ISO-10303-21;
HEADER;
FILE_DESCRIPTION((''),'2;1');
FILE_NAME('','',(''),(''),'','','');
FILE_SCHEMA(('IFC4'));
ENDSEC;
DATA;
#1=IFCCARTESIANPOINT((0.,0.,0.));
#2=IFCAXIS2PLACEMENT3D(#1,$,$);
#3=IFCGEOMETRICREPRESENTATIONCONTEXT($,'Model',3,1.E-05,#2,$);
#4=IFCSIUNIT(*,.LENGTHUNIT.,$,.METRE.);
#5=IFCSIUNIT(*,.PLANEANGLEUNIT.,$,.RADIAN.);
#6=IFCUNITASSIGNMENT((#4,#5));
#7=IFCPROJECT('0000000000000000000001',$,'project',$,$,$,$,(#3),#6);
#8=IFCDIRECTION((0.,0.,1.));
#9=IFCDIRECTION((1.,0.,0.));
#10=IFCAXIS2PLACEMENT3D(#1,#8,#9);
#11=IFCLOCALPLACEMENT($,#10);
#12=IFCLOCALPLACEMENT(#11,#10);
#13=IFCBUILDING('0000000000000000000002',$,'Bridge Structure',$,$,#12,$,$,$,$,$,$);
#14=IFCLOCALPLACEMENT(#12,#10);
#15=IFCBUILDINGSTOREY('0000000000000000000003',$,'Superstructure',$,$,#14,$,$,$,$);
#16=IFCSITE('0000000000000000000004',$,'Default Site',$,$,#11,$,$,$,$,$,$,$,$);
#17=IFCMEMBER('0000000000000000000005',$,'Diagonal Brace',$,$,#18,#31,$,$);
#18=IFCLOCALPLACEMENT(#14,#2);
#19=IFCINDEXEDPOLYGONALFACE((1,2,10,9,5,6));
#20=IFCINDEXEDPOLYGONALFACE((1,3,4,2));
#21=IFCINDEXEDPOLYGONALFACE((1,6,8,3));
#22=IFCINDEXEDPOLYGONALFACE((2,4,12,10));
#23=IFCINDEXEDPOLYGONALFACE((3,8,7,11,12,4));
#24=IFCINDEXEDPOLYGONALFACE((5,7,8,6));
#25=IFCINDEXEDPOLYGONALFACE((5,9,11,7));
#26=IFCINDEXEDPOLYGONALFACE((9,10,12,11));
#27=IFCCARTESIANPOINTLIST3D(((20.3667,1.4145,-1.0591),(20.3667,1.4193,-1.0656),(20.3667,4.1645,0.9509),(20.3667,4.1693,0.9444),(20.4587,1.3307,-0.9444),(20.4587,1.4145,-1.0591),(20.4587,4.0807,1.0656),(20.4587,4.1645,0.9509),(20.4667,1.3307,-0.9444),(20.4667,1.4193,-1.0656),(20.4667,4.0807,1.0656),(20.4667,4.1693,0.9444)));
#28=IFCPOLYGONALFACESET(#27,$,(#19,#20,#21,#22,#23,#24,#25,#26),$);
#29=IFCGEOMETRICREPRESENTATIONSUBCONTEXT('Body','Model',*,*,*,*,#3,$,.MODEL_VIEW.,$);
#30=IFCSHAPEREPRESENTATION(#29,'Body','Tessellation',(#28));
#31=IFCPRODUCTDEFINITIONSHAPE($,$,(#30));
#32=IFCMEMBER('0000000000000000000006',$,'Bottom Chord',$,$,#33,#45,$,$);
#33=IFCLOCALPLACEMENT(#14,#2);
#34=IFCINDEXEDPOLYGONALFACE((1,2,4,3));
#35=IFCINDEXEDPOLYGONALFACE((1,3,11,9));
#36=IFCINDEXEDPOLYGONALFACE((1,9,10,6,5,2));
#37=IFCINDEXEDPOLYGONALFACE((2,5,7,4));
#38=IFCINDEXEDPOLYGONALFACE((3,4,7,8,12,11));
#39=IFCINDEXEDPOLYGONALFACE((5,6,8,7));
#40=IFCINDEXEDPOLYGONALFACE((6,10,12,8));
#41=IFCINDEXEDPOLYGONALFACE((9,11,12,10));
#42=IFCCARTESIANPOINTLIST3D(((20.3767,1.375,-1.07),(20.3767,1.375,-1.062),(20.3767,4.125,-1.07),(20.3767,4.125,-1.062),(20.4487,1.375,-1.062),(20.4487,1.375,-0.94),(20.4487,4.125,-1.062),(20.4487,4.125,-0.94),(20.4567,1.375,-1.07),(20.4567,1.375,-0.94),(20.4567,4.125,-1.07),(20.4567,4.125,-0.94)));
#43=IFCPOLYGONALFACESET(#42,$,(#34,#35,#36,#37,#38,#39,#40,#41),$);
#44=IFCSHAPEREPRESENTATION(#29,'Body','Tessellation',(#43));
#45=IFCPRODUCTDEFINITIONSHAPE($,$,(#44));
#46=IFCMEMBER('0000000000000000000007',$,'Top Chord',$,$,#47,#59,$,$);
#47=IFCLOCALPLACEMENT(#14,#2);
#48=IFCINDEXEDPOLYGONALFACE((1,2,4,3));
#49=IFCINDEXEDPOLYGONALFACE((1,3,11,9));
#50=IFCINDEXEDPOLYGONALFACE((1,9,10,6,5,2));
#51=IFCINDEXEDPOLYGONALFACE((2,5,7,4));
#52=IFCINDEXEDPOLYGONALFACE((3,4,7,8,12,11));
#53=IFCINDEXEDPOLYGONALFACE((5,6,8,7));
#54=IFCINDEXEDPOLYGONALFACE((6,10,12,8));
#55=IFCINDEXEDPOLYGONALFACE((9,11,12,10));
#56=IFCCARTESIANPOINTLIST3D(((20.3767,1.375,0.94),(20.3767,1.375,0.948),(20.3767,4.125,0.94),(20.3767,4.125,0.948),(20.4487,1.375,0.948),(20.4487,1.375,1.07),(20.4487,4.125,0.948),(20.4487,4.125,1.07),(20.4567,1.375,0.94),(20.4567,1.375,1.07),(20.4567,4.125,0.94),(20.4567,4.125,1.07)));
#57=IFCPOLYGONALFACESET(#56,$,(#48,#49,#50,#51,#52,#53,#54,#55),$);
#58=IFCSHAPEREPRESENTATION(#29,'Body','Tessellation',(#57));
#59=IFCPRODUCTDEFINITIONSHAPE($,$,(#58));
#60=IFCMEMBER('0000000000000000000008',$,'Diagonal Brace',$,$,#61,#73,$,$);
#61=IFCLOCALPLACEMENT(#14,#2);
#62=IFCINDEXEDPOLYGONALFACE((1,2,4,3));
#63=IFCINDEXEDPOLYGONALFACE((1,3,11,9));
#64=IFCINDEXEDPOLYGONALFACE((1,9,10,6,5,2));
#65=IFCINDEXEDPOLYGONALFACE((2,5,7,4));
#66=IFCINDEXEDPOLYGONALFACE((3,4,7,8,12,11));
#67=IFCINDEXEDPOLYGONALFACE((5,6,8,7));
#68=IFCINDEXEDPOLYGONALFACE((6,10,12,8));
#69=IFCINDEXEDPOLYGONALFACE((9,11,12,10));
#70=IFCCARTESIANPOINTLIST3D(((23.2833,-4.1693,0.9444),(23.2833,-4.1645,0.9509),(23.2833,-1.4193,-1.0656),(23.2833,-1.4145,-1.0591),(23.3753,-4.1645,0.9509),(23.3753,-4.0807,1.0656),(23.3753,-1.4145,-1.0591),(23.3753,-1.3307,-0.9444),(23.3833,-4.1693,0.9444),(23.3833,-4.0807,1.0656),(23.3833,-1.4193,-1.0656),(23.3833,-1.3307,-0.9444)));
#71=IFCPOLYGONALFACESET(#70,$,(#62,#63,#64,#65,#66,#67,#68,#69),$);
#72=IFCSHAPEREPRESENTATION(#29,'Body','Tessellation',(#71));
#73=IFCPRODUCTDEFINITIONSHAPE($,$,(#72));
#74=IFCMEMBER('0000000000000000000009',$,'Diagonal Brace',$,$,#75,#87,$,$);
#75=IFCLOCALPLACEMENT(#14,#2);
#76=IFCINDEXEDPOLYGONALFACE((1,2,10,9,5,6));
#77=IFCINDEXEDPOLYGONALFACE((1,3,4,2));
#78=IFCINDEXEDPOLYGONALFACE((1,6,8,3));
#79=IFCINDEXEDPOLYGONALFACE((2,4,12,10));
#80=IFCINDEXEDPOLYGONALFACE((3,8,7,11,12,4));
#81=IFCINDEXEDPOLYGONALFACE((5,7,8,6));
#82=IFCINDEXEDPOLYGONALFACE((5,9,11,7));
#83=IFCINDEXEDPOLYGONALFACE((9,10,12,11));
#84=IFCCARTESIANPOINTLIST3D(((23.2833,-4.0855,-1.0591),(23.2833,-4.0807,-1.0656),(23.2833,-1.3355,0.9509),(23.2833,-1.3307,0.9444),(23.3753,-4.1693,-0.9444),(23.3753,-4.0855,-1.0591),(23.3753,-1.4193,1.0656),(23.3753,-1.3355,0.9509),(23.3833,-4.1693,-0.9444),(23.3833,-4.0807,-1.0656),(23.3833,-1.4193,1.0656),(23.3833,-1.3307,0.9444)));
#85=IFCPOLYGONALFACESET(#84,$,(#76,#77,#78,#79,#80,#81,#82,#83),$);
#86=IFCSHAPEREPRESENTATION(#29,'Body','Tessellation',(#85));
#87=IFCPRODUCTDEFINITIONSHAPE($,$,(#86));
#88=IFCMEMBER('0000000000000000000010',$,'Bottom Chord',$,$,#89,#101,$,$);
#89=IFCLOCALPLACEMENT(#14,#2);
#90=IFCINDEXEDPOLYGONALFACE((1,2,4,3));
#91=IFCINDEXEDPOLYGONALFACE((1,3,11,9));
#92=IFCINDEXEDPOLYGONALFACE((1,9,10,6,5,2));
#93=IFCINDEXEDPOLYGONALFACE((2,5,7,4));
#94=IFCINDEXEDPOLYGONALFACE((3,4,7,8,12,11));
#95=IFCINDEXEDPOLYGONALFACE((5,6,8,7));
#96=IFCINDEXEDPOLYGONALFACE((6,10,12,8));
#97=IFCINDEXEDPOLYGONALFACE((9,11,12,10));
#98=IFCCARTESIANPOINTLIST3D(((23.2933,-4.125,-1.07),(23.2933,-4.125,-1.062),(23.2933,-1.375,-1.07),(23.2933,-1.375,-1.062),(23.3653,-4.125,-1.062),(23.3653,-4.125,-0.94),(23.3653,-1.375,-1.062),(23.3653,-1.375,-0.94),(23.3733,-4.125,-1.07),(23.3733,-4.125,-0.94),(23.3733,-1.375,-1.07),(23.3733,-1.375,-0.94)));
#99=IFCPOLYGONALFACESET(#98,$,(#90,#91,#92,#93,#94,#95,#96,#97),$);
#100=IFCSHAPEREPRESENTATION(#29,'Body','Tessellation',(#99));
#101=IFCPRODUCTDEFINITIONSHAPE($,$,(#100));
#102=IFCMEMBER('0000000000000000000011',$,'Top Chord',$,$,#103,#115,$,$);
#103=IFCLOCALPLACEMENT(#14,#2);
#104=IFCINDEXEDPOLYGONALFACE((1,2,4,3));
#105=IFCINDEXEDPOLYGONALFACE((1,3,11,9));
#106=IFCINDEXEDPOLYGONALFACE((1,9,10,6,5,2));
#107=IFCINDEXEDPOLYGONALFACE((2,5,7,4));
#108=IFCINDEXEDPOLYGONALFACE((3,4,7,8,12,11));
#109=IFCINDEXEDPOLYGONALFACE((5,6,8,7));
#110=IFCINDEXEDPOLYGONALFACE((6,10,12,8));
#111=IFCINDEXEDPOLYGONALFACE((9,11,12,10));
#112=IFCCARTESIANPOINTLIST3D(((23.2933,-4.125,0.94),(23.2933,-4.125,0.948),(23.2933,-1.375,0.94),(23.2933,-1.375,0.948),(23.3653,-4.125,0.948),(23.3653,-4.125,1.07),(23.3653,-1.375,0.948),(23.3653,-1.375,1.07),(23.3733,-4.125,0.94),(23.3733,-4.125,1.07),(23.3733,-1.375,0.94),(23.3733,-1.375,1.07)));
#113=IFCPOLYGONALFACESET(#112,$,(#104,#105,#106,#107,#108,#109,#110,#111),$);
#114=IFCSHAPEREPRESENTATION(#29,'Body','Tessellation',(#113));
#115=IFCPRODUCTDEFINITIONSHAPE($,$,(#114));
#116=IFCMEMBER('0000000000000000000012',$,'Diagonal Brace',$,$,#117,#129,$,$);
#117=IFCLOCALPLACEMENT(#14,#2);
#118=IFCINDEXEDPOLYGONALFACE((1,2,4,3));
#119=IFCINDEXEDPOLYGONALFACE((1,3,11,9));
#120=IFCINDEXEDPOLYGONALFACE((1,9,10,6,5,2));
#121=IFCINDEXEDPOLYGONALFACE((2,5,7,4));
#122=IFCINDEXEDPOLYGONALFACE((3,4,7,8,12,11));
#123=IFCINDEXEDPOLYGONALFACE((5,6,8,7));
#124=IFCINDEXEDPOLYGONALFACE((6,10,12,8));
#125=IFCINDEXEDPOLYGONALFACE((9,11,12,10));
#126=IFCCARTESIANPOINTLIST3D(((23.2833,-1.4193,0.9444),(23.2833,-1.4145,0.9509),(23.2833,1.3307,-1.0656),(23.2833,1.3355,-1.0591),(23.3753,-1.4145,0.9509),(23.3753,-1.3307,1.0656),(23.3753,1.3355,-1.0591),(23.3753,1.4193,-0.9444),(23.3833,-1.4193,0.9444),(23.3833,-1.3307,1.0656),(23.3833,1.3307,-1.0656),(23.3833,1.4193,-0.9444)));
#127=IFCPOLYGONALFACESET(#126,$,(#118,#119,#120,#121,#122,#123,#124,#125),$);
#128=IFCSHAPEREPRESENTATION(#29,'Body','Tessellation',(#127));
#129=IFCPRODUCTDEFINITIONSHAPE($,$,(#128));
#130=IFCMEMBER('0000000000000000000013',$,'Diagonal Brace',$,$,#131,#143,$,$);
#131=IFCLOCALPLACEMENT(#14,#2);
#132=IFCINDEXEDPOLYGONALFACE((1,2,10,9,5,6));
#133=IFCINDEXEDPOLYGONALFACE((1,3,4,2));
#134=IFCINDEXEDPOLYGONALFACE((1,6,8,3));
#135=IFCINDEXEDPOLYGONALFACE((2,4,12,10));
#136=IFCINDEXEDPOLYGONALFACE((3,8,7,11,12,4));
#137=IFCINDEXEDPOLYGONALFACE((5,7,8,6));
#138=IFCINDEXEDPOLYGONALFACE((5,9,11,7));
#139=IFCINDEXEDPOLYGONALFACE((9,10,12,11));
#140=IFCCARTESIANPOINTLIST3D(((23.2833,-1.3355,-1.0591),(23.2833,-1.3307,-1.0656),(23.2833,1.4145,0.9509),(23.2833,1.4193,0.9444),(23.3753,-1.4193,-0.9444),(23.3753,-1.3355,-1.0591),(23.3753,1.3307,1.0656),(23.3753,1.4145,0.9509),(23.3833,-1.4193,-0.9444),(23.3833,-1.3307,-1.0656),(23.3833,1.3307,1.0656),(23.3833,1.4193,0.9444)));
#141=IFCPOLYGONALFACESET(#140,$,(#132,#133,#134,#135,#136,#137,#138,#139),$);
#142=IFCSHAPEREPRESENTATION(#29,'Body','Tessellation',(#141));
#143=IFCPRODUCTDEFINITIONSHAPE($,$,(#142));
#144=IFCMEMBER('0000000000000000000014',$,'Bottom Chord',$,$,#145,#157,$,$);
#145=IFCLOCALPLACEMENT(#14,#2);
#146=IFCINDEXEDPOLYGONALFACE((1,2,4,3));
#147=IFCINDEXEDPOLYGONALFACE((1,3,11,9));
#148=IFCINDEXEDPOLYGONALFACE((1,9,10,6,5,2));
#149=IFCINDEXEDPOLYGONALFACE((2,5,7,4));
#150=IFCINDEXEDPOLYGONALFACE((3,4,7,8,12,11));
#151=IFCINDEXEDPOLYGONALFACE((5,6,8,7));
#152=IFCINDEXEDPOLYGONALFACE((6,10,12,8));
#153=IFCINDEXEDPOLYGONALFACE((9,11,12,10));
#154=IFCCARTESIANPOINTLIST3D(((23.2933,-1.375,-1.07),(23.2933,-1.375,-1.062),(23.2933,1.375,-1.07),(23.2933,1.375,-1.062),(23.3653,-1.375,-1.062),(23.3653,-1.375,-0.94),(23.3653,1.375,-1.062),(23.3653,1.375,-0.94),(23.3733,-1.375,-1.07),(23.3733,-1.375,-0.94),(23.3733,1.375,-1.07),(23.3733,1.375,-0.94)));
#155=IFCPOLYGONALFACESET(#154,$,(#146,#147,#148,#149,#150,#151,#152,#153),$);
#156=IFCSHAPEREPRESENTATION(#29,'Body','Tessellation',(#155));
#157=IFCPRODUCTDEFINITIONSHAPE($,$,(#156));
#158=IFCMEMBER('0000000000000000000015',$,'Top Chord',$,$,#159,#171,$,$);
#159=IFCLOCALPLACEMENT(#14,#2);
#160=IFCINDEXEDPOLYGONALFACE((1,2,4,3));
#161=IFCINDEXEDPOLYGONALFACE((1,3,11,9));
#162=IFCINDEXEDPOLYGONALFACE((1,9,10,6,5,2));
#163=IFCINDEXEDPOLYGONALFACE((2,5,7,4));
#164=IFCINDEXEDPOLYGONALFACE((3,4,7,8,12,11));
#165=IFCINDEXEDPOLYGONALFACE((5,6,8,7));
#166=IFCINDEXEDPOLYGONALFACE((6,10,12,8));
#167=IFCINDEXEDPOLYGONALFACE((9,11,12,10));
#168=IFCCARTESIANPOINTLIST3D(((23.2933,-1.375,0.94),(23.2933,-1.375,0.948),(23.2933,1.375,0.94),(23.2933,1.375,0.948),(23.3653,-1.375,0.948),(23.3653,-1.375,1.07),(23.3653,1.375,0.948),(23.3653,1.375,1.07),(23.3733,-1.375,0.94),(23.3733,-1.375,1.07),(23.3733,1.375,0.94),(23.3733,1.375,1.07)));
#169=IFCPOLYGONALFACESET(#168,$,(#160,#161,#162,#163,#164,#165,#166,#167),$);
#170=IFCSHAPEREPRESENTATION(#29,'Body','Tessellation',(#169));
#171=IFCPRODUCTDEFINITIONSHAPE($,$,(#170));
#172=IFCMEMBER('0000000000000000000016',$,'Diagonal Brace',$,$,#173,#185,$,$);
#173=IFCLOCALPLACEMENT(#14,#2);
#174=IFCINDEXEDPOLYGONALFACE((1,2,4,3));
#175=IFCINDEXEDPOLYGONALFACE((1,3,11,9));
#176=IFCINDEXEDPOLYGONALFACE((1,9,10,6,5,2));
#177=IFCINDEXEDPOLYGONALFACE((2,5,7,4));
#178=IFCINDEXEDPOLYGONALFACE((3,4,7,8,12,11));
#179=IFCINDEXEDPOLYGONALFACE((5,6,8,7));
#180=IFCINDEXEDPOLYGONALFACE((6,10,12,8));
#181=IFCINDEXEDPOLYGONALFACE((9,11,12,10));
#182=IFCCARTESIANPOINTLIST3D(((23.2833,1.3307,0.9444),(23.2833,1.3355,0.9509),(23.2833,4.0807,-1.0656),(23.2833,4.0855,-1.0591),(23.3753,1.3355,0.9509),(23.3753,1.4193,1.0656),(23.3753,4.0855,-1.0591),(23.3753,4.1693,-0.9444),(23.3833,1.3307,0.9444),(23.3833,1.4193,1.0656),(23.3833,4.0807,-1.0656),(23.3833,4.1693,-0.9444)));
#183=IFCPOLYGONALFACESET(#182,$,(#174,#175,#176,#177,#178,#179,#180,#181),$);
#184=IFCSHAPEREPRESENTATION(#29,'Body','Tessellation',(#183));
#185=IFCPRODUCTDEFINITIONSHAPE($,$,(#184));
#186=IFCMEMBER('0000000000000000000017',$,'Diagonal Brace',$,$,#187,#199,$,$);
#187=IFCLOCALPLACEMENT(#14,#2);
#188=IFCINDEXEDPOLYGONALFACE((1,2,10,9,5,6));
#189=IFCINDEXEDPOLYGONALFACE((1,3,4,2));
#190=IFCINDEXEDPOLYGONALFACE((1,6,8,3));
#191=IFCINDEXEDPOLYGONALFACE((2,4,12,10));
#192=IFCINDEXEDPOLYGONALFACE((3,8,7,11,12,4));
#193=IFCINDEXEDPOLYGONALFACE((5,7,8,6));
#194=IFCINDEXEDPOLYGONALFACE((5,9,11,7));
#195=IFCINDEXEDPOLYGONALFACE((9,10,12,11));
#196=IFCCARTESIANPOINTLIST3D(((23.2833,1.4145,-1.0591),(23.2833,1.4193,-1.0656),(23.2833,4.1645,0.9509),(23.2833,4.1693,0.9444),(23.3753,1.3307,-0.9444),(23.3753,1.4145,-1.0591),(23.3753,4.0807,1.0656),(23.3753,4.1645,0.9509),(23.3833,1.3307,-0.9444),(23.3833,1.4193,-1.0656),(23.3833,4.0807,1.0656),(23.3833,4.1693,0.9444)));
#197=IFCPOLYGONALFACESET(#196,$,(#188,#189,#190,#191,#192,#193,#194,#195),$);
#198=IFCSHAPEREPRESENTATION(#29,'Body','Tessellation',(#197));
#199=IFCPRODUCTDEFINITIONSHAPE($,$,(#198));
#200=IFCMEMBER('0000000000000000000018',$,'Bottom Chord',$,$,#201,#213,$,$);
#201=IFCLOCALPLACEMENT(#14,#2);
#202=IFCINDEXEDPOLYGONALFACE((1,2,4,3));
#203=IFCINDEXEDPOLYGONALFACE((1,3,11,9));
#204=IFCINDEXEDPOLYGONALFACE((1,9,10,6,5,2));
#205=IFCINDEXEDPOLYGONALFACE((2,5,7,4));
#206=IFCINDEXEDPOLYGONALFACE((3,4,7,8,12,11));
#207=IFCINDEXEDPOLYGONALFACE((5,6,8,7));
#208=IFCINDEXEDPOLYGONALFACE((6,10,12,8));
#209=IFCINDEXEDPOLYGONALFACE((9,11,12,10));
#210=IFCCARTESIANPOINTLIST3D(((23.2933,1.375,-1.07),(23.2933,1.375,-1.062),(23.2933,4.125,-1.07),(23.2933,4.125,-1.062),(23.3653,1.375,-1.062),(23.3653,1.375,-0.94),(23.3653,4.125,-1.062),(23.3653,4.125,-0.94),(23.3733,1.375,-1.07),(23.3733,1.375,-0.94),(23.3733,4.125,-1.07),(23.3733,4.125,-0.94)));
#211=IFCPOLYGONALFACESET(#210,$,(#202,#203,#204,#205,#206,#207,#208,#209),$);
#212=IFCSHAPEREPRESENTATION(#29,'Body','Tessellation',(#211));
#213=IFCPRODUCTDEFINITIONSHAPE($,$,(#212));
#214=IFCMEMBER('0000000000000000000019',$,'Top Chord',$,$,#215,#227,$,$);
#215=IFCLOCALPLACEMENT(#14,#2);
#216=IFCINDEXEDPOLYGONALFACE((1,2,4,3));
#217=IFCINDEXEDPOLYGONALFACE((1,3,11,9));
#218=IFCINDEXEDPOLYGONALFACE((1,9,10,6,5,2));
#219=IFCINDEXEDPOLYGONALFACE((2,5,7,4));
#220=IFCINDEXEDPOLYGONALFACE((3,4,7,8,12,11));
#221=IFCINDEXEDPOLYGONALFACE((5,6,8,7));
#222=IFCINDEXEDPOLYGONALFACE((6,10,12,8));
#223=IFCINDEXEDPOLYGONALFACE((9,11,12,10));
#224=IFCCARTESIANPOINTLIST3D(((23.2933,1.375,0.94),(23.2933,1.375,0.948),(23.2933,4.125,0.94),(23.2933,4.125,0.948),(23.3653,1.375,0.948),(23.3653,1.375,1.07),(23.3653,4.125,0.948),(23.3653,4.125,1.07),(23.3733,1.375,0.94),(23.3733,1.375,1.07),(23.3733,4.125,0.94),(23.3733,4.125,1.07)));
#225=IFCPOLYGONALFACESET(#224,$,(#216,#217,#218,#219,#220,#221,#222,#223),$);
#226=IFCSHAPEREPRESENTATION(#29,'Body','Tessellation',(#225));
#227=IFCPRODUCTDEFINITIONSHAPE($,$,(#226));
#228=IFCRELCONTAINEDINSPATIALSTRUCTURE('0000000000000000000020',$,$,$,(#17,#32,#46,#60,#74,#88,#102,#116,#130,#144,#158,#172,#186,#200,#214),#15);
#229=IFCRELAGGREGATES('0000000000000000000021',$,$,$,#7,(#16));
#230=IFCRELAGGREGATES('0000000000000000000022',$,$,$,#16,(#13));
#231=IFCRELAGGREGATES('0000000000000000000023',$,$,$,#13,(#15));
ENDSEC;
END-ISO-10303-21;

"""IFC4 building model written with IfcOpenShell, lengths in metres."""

from ifc_helpers import new_model, si_unit, frame, origin, origin_with_axes, origin_2d_with_axis, place, context, subcontext, project, spatial, l_section, extrude, element, save


model = new_model("IFC4")

# Units and contexts
model_context = context("Model", 3, precision=1e-05, world=origin())
body_context = subcontext(model_context, "Body", "Model", "MODEL_VIEW")
ifc_project = project(units=[si_unit("LENGTHUNIT", "METRE"), si_unit("PLANEANGLEUNIT", "RADIAN")], contexts=[model_context])

# Site, building, storey
site_placement = place(None, origin_with_axes())
site = spatial("IfcSite", under=ifc_project, at=site_placement, Name="Default Site")
building_placement = place(site_placement, origin_with_axes())
building = spatial("IfcBuilding", under=site, at=building_placement, Name="Bridge Structure")
storey_placement = place(building_placement, origin_with_axes())
storey = spatial("IfcBuildingStorey", under=building, at=storey_placement, Name="Superstructure")

# Members
member_1_placement = place(storey_placement, frame((20.4167, 1.375, -1.005), z_axis=(0.0, 0.807337, 0.59009), x_axis=(-1.0, 0.0, 0.0)))
element("IfcMember", 1, at=member_1_placement, inside=storey, Name="Diagonal Brace", context=body_context, shape_type="SweptSolid", body=[
    extrude(l_section(Depth=0.15, Width=0.1, Thickness=0.008, at=origin_2d_with_axis()), origin_with_axes(), (0.0, 0.0, 1.0), 3.4063),
])
for number, where, z_axis, x_axis, name in (
    (2, (20.4167, 1.375, -1.005), (0.0, 1.0, 0.0), (-1.0, 0.0, 0.0), "Bottom Chord"),
    (3, (20.4167, 1.375, 1.005), (0.0, 1.0, 0.0), (-1.0, 0.0, 0.0), "Top Chord"),
):
    element("IfcMember", number, at=place(storey_placement, frame(where, z_axis=z_axis, x_axis=x_axis)), inside=storey, Name=name, context=body_context, shape_type="SweptSolid", body=[
        extrude(l_section(Depth=0.13, Width=0.08, Thickness=0.008, at=origin_2d_with_axis()), origin_with_axes(), (0.0, 0.0, 1.0), 2.75),
    ])
for number, where, z_axis, x_axis, name in (
    (4, (23.3333, -4.125, 1.005), (0.0, 0.807337, -0.59009), (-1.0, 0.0, 0.0), "Diagonal Brace"),
    (5, (23.3333, -4.125, -1.005), (0.0, 0.807337, 0.59009), (-1.0, 0.0, 0.0), "Diagonal Brace"),
):
    element("IfcMember", number, at=place(storey_placement, frame(where, z_axis=z_axis, x_axis=x_axis)), inside=storey, Name=name, context=body_context, shape_type="SweptSolid", body=[
        extrude(l_section(Depth=0.15, Width=0.1, Thickness=0.008, at=origin_2d_with_axis()), origin_with_axes(), (0.0, 0.0, 1.0), 3.4063),
    ])
for number, where, z_axis, x_axis, name in (
    (6, (23.3333, -4.125, -1.005), (0.0, 1.0, 0.0), (-1.0, 0.0, 0.0), "Bottom Chord"),
    (7, (23.3333, -4.125, 1.005), (0.0, 1.0, 0.0), (-1.0, 0.0, 0.0), "Top Chord"),
):
    element("IfcMember", number, at=place(storey_placement, frame(where, z_axis=z_axis, x_axis=x_axis)), inside=storey, Name=name, context=body_context, shape_type="SweptSolid", body=[
        extrude(l_section(Depth=0.13, Width=0.08, Thickness=0.008, at=origin_2d_with_axis()), origin_with_axes(), (0.0, 0.0, 1.0), 2.75),
    ])
for number, where, z_axis, x_axis, name in (
    (8, (23.3333, -1.375, 1.005), (0.0, 0.807337, -0.59009), (-1.0, 0.0, 0.0), "Diagonal Brace"),
    (9, (23.3333, -1.375, -1.005), (0.0, 0.807337, 0.59009), (-1.0, 0.0, 0.0), "Diagonal Brace"),
):
    element("IfcMember", number, at=place(storey_placement, frame(where, z_axis=z_axis, x_axis=x_axis)), inside=storey, Name=name, context=body_context, shape_type="SweptSolid", body=[
        extrude(l_section(Depth=0.15, Width=0.1, Thickness=0.008, at=origin_2d_with_axis()), origin_with_axes(), (0.0, 0.0, 1.0), 3.4063),
    ])
for number, where, z_axis, x_axis, name in (
    (10, (23.3333, -1.375, -1.005), (0.0, 1.0, 0.0), (-1.0, 0.0, 0.0), "Bottom Chord"),
    (11, (23.3333, -1.375, 1.005), (0.0, 1.0, 0.0), (-1.0, 0.0, 0.0), "Top Chord"),
):
    element("IfcMember", number, at=place(storey_placement, frame(where, z_axis=z_axis, x_axis=x_axis)), inside=storey, Name=name, context=body_context, shape_type="SweptSolid", body=[
        extrude(l_section(Depth=0.13, Width=0.08, Thickness=0.008, at=origin_2d_with_axis()), origin_with_axes(), (0.0, 0.0, 1.0), 2.75),
    ])
for number, where, z_axis, x_axis, name in (
    (12, (23.3333, 1.375, 1.005), (0.0, 0.807337, -0.59009), (-1.0, 0.0, 0.0), "Diagonal Brace"),
    (13, (23.3333, 1.375, -1.005), (0.0, 0.807337, 0.59009), (-1.0, 0.0, 0.0), "Diagonal Brace"),
):
    element("IfcMember", number, at=place(storey_placement, frame(where, z_axis=z_axis, x_axis=x_axis)), inside=storey, Name=name, context=body_context, shape_type="SweptSolid", body=[
        extrude(l_section(Depth=0.15, Width=0.1, Thickness=0.008, at=origin_2d_with_axis()), origin_with_axes(), (0.0, 0.0, 1.0), 3.4063),
    ])
for number, where, z_axis, x_axis, name in (
    (14, (23.3333, 1.375, -1.005), (0.0, 1.0, 0.0), (-1.0, 0.0, 0.0), "Bottom Chord"),
    (15, (23.3333, 1.375, 1.005), (0.0, 1.0, 0.0), (-1.0, 0.0, 0.0), "Top Chord"),
):
    element("IfcMember", number, at=place(storey_placement, frame(where, z_axis=z_axis, x_axis=x_axis)), inside=storey, Name=name, context=body_context, shape_type="SweptSolid", body=[
        extrude(l_section(Depth=0.13, Width=0.08, Thickness=0.008, at=origin_2d_with_axis()), origin_with_axes(), (0.0, 0.0, 1.0), 2.75),
    ])

save(model, "model.ifc")
